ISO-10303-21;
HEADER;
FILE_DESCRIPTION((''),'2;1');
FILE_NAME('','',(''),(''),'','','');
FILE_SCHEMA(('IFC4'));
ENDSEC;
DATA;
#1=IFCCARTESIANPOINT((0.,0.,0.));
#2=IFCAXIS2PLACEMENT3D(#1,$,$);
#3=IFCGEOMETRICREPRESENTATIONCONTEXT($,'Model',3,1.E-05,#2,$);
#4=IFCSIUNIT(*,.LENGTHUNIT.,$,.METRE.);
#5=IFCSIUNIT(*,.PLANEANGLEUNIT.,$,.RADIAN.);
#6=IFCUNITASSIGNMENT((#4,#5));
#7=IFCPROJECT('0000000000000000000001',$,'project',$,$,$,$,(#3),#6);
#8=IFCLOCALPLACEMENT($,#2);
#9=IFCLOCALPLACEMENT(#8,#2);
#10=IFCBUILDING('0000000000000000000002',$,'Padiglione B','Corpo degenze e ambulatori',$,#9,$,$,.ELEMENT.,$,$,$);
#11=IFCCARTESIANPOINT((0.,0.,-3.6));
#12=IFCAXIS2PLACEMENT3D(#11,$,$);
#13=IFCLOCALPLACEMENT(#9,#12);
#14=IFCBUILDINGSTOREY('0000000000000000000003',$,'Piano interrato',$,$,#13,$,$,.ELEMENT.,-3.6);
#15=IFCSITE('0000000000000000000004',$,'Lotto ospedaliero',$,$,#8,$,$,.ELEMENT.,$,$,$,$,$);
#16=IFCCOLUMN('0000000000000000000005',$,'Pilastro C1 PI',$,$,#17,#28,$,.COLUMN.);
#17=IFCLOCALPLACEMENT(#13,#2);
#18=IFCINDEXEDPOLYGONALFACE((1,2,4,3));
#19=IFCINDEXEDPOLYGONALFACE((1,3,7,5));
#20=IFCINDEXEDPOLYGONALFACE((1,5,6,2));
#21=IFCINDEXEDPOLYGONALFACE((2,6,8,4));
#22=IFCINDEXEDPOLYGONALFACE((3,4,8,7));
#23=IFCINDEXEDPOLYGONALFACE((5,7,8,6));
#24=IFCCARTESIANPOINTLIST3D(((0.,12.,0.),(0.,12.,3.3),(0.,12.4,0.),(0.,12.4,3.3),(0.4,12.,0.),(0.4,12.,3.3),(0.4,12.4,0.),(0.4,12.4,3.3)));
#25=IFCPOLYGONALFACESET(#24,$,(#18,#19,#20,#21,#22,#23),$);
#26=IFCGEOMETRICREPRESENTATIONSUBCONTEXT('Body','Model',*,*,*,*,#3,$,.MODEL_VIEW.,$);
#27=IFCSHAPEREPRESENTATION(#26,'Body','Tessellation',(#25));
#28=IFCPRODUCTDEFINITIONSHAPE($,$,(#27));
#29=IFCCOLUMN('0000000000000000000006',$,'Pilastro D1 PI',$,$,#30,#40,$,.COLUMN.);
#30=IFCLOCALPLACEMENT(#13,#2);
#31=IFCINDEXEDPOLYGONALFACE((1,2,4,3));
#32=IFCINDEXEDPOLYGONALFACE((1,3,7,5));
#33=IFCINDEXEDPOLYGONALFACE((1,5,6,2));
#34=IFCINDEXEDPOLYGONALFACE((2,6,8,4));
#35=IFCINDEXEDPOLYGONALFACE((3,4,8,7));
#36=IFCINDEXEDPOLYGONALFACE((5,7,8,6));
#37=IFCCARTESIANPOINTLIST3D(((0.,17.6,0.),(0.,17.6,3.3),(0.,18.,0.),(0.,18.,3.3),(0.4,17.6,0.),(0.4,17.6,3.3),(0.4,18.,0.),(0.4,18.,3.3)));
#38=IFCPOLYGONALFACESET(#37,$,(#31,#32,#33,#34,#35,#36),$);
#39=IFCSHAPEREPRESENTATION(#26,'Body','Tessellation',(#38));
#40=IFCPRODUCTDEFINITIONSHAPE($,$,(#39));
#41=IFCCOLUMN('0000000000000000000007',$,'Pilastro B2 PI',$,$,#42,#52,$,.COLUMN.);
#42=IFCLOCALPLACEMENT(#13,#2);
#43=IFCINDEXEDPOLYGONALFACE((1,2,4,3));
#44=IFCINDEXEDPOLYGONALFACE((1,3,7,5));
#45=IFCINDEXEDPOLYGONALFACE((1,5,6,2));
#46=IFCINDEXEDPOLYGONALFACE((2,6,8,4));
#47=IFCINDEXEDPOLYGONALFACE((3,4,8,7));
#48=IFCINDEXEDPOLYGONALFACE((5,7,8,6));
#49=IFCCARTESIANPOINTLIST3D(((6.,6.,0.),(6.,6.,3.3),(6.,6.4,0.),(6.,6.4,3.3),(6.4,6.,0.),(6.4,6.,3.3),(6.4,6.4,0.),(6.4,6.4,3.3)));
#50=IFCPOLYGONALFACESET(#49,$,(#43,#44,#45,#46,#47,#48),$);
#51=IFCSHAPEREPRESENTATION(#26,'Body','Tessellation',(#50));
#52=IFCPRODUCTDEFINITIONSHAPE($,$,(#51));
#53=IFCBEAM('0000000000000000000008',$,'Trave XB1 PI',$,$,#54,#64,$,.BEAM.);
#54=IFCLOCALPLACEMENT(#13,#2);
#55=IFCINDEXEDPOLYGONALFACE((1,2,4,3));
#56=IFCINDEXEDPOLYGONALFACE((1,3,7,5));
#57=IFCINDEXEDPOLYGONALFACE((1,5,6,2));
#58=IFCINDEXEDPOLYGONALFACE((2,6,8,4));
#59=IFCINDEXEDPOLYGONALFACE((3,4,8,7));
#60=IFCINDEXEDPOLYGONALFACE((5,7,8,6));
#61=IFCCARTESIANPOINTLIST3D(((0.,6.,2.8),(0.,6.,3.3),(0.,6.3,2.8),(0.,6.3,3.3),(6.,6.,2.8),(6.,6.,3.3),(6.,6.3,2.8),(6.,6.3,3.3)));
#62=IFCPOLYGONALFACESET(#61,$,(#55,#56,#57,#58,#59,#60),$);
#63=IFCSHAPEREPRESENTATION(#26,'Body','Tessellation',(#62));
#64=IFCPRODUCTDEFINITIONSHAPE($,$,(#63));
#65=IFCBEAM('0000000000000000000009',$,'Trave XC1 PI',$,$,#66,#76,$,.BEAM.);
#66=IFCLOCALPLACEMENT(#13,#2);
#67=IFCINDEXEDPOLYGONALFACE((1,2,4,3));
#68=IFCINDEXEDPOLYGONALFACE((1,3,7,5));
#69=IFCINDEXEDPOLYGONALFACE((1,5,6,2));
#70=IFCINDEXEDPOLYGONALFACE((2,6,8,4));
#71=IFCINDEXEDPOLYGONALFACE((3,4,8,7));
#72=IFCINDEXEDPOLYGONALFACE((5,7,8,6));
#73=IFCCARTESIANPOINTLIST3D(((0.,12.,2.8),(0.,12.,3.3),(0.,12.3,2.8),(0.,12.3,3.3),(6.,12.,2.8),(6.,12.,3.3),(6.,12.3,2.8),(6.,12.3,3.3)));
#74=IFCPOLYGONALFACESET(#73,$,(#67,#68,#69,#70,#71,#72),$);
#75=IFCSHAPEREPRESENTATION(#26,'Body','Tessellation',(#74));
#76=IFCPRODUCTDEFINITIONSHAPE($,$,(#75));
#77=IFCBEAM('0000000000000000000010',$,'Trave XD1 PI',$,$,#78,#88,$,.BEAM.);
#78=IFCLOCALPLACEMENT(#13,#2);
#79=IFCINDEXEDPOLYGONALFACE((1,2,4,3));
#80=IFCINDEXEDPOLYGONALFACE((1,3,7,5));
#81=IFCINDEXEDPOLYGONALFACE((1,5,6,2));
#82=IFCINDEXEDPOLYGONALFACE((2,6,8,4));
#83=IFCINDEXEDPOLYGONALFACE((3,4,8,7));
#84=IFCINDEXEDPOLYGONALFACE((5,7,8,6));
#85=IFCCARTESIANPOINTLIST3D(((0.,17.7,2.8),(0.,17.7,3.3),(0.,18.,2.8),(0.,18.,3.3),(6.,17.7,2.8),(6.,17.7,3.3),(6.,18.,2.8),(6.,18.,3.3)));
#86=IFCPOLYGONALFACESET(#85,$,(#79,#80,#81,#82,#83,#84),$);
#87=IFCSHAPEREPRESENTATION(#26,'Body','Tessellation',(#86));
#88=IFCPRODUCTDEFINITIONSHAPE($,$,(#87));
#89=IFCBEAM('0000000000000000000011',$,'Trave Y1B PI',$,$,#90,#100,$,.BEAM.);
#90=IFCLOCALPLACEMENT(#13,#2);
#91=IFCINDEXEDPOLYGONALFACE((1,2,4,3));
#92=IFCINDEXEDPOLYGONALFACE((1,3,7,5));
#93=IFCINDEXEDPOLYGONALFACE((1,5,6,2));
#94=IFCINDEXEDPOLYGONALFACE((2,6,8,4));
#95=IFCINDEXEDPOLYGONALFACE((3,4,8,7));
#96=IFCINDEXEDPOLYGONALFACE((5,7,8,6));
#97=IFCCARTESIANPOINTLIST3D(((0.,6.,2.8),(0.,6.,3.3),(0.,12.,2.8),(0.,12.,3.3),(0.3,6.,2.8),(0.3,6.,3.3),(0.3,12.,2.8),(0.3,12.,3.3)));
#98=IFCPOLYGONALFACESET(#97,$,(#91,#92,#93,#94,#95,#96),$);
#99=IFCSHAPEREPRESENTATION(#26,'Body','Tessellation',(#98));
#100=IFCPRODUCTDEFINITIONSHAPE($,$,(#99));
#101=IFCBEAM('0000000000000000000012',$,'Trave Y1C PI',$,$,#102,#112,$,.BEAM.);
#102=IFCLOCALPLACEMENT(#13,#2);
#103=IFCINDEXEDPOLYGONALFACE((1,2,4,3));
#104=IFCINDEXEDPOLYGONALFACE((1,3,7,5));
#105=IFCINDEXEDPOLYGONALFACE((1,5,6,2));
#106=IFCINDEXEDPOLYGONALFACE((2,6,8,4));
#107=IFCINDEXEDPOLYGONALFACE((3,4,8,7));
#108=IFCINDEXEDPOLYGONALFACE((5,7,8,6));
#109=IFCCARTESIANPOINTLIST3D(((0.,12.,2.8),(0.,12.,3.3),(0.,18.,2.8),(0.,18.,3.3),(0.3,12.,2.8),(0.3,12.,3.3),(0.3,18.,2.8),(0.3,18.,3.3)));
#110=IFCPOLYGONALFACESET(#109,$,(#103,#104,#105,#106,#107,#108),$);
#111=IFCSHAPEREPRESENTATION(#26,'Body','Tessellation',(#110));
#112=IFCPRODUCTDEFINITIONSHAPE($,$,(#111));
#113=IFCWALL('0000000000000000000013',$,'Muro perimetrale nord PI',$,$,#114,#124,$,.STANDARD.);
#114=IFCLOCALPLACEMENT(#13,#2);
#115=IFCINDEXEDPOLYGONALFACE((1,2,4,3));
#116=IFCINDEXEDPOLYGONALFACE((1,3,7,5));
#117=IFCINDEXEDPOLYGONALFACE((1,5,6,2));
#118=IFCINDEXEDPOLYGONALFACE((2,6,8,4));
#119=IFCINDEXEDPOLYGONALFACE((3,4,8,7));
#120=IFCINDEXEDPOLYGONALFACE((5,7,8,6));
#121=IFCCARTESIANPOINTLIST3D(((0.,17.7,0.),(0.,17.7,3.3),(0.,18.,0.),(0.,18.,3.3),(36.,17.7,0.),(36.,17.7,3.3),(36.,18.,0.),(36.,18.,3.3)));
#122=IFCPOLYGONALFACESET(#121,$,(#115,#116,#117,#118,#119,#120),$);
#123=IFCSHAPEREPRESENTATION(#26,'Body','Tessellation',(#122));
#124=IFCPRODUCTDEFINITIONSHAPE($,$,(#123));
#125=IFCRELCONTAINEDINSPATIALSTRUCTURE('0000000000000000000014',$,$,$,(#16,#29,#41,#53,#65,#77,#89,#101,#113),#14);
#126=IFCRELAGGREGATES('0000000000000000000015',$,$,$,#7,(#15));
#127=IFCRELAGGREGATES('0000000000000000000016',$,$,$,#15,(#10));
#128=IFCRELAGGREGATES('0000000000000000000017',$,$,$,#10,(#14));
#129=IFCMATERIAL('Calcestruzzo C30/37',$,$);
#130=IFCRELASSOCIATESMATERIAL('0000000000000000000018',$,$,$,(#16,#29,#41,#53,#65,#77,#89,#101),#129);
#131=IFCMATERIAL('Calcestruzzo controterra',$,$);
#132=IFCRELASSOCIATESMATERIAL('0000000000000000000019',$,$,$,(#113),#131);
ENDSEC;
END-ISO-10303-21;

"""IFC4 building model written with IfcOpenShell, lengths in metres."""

from ifc_helpers import new_model, si_unit, frame, frame_2d, origin, place, context, subcontext, project, spatial, rectangle, extrude, material, element, save


model = new_model("IFC4")

# Units and contexts
model_context = context("Model", 3, precision=1e-05, world=origin())
body_context = subcontext(model_context, "Body", "Model", "MODEL_VIEW")
ifc_project = project(units=[si_unit("LENGTHUNIT", "METRE"), si_unit("PLANEANGLEUNIT", "RADIAN")], contexts=[model_context])

# Site, building, storey
site_placement = place(None, origin())
site = spatial("IfcSite", under=ifc_project, at=site_placement, Name="Lotto ospedaliero", CompositionType="ELEMENT")
building_placement = place(site_placement, origin())
building = spatial("IfcBuilding", under=site, at=building_placement, Name="Padiglione B", Description="Corpo degenze e ambulatori", CompositionType="ELEMENT")
storey_placement = place(building_placement, frame((0.0, 0.0, -3.6)))
storey = spatial("IfcBuildingStorey", under=building, at=storey_placement, Name="Piano interrato", CompositionType="ELEMENT", Elevation=-3.6)

# Columns
ifc_material_1 = material(Name="Calcestruzzo C30/37")
for number, where, name in (
    (1, (0.0, 12.0, 0.0), "Pilastro C1 PI"),
    (2, (0.0, 17.6, 0.0), "Pilastro D1 PI"),
    (3, (6.0, 6.0, 0.0), "Pilastro B2 PI"),
):
    element("IfcColumn", number, at=place(storey_placement, frame(where)), inside=storey, material=ifc_material_1, Name=name, PredefinedType="COLUMN", context=body_context, shape_type="SweptSolid", body=[
        extrude(rectangle(XDim=0.4, YDim=0.4, at=frame_2d((0.2, 0.2))), origin(), (0.0, 0.0, 1.0), 3.3),
    ])

# Beams
for number, where, name in (
    (4, (0.0, 6.0, 2.8), "Trave XB1 PI"),
    (5, (0.0, 12.0, 2.8), "Trave XC1 PI"),
    (6, (0.0, 17.7, 2.8), "Trave XD1 PI"),
):
    element("IfcBeam", number, at=place(storey_placement, frame(where)), inside=storey, material=ifc_material_1, Name=name, PredefinedType="BEAM", context=body_context, shape_type="SweptSolid", body=[
        extrude(rectangle(XDim=6.0, YDim=0.3, at=frame_2d((3.0, 0.15))), origin(), (0.0, 0.0, 1.0), 0.5),
    ])
for number, where, name in (
    (7, (0.0, 6.0, 2.8), "Trave Y1B PI"),
    (8, (0.0, 12.0, 2.8), "Trave Y1C PI"),
):
    element("IfcBeam", number, at=place(storey_placement, frame(where)), inside=storey, material=ifc_material_1, Name=name, PredefinedType="BEAM", context=body_context, shape_type="SweptSolid", body=[
        extrude(rectangle(XDim=0.3, YDim=6.0, at=frame_2d((0.15, 3.0))), origin(), (0.0, 0.0, 1.0), 0.5),
    ])

# Wall
ifc_material_2 = material(Name="Calcestruzzo controterra")
wall_1_placement = place(storey_placement, frame((0.0, 17.7, 0.0)))
element("IfcWall", 9, at=wall_1_placement, inside=storey, material=ifc_material_2, Name="Muro perimetrale nord PI", PredefinedType="STANDARD", context=body_context, shape_type="SweptSolid", body=[
    extrude(rectangle(XDim=36.0, YDim=0.3, at=frame_2d((18.0, 0.15))), origin(), (0.0, 0.0, 1.0), 3.3),
])

save(model, "model.ifc")
